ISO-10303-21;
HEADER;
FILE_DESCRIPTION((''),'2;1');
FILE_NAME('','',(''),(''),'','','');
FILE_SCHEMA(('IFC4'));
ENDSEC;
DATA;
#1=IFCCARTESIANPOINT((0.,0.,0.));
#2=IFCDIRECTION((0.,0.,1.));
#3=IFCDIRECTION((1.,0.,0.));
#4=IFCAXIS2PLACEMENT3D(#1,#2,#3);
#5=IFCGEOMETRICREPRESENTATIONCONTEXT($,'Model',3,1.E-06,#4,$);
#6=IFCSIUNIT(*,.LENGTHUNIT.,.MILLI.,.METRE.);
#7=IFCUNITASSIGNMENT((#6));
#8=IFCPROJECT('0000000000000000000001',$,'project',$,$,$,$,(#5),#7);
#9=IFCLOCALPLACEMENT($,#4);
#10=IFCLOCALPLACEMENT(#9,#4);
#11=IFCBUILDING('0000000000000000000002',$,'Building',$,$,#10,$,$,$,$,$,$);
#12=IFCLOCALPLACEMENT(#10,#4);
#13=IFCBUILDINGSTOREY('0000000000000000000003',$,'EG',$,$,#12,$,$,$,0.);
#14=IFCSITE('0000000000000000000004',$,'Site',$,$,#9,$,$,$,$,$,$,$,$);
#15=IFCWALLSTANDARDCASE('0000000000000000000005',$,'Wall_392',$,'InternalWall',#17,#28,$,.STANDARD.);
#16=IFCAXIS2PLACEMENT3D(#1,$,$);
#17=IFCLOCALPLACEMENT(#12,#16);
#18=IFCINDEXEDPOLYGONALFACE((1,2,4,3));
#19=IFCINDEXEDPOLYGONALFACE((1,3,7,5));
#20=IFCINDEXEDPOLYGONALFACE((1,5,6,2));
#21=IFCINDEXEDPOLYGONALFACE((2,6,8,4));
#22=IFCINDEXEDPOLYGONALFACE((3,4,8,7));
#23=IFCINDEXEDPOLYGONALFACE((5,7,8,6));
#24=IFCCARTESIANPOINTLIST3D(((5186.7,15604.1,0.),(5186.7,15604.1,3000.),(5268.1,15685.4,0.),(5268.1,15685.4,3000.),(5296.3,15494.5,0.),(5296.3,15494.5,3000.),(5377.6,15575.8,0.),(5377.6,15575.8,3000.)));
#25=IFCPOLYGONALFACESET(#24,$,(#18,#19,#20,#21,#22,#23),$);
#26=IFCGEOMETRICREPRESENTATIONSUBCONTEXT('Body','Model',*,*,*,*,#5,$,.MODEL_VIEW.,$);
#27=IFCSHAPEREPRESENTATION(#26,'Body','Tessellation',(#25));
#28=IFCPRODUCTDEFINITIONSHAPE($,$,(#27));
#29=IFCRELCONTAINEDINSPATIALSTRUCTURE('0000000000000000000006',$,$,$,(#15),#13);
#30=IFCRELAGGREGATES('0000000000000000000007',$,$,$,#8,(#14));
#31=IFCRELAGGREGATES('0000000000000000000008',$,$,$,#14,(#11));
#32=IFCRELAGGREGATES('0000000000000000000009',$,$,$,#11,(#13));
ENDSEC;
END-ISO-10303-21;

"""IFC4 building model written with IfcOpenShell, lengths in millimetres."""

from ifc_helpers import new_model, si_unit, frame, origin_with_axes, place, context, subcontext, project, spatial, rectangle, extrude, element, save


model = new_model("IFC4")

# Units and contexts
model_context = context("Model", 3, precision=1e-06, world=origin_with_axes())
body_context = subcontext(model_context, "Body", "Model", "MODEL_VIEW")
ifc_project = project(units=[si_unit("LENGTHUNIT", "METRE", prefix="MILLI")], contexts=[model_context])

# Site, building, storey
site_placement = place(None, origin_with_axes())
site = spatial("IfcSite", under=ifc_project, at=site_placement, Name="Site")
building_placement = place(site_placement, origin_with_axes())
building = spatial("IfcBuilding", under=site, at=building_placement, Name="Building")
storey_placement = place(building_placement, origin_with_axes())
storey = spatial("IfcBuildingStorey", under=building, at=storey_placement, Name="EG", Elevation=0.0)

# Wall
wall_1_placement = place(storey_placement, origin_with_axes())
element("IfcWallStandardCase", 1, at=wall_1_placement, inside=storey, Name="Wall_392", ObjectType="InternalWall", PredefinedType="STANDARD", context=body_context, shape_type="SweptSolid", body=[
    extrude(rectangle(XDim=155.0, YDim=115.0), frame((5282.2, 15590.0, 0.0), z_axis=(0.0, 0.0, 1.0), x_axis=(-0.707107, 0.707107, 0.0)), (0.0, 0.0, 1.0), 3000.0),
])

save(model, "model.ifc")
